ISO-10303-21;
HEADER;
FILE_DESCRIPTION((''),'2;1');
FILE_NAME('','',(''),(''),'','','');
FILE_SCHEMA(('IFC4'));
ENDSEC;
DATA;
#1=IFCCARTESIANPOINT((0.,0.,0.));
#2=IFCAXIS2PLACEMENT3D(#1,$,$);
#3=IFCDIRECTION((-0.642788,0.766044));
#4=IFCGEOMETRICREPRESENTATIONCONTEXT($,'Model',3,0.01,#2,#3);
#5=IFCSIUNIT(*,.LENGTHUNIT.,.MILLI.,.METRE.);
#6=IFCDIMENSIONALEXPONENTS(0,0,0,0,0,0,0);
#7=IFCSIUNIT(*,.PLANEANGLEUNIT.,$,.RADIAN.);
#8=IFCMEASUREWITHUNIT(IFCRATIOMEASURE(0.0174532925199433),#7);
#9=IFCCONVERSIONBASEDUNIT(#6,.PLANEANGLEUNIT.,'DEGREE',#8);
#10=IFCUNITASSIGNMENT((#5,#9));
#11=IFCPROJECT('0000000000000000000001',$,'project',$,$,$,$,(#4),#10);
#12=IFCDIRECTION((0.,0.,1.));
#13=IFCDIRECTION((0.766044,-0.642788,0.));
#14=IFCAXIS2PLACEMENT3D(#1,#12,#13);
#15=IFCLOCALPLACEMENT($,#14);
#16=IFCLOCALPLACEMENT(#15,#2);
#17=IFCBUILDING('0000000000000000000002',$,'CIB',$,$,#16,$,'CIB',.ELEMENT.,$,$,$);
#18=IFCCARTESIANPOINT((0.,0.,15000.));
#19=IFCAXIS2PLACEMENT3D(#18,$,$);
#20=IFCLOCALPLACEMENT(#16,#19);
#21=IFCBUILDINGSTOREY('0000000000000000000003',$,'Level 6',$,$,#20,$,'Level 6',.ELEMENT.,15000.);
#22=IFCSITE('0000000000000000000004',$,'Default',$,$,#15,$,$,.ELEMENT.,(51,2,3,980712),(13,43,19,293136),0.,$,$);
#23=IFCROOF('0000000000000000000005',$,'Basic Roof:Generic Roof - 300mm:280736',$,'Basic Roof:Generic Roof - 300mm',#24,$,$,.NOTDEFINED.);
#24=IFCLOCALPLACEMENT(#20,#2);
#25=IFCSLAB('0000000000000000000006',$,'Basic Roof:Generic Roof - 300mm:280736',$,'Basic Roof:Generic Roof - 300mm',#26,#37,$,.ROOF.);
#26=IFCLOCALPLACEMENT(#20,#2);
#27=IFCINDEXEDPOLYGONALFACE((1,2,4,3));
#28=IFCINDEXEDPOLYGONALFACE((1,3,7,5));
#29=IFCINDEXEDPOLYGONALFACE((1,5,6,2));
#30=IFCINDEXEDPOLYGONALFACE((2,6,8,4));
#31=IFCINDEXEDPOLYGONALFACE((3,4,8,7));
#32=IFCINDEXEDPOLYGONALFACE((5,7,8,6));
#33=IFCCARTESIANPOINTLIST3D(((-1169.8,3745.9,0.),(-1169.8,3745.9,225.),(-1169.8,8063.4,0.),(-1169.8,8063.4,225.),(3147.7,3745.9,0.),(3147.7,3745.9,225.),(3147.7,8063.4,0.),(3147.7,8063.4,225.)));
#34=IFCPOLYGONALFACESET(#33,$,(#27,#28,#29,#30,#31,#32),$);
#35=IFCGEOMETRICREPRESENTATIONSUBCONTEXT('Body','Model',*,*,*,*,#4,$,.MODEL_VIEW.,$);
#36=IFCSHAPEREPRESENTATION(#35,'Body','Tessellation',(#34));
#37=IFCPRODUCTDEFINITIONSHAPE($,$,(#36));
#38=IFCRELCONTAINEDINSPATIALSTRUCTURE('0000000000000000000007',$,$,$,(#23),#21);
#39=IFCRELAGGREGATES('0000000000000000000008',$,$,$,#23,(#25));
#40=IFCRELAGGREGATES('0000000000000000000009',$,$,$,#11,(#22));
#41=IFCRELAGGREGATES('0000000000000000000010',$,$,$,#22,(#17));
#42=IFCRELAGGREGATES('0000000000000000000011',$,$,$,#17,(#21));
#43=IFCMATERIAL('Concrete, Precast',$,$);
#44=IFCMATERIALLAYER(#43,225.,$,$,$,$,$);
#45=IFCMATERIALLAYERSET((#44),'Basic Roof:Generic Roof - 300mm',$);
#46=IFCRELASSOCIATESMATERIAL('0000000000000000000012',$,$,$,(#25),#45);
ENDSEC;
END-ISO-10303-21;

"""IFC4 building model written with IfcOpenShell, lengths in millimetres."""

from ifc_helpers import new_model, entity, si_unit, converted_unit, direction, frame, frame_2d, origin, place, context, subcontext, project, spatial, rectangle, extrude, material, layer, layer_set, element, aggregate, save


model = new_model("IFC4")

# Units and contexts
model_context = context("Model", 3, precision=0.01, world=origin(), true_north=direction((-0.642788, 0.766044)))
body_context = subcontext(model_context, "Body", "Model", "MODEL_VIEW")
ifc_project = project(units=[si_unit("LENGTHUNIT", "METRE", prefix="MILLI"), converted_unit("PLANEANGLEUNIT", "DEGREE", entity("IfcRatioMeasure", 0.0174532925199433), si_unit("PLANEANGLEUNIT", "RADIAN"), dimensions=[0, 0, 0, 0, 0, 0, 0])], contexts=[model_context])

# Site, building, storey
site_placement = place(None, frame((0.0, 0.0, 0.0), z_axis=(0.0, 0.0, 1.0), x_axis=(0.766044, -0.642788, 0.0)))
site = spatial("IfcSite", under=ifc_project, at=site_placement, Name="Default", CompositionType="ELEMENT", RefLatitude=(51, 2, 3, 980712), RefLongitude=(13, 43, 19, 293136), RefElevation=0.0)
building_placement = place(site_placement, origin())
building = spatial("IfcBuilding", under=site, at=building_placement, Name="CIB", LongName="CIB", CompositionType="ELEMENT")
storey_placement = place(building_placement, frame((0.0, 0.0, 15000.0)))
storey = spatial("IfcBuildingStorey", under=building, at=storey_placement, Name="Level 6", LongName="Level 6", CompositionType="ELEMENT", Elevation=15000.0)

# Roof, slab
roof_placement = place(storey_placement, frame((-1169.8, 3745.9, 0.0)))
roof = element("IfcRoof", 1, at=roof_placement, inside=storey, Name="Basic Roof:Generic Roof - 300mm:280736", ObjectType="Basic Roof:Generic Roof - 300mm", PredefinedType="NOTDEFINED")
ifc_material = material(Name="Concrete, Precast")
ifc_layer = layer(ifc_material, 225.0)
ifc_layer_set = layer_set([ifc_layer], Name="Basic Roof:Generic Roof - 300mm")
slab_placement = place(roof_placement, origin())
slab = element("IfcSlab", 2, at=slab_placement, material=ifc_layer_set, Name="Basic Roof:Generic Roof - 300mm:280736", ObjectType="Basic Roof:Generic Roof - 300mm", PredefinedType="ROOF", context=body_context, shape_type="SweptSolid", body=[
    extrude(rectangle(XDim=4317.5, YDim=4317.5, at=frame_2d((0.0, 0.0), x_axis=(0.0, 1.0))), frame((2158.8, 2158.8, 0.0)), (0.0, 0.0, 1.0), 225.0),
])
aggregate(roof, [slab])

save(model, "model.ifc")
